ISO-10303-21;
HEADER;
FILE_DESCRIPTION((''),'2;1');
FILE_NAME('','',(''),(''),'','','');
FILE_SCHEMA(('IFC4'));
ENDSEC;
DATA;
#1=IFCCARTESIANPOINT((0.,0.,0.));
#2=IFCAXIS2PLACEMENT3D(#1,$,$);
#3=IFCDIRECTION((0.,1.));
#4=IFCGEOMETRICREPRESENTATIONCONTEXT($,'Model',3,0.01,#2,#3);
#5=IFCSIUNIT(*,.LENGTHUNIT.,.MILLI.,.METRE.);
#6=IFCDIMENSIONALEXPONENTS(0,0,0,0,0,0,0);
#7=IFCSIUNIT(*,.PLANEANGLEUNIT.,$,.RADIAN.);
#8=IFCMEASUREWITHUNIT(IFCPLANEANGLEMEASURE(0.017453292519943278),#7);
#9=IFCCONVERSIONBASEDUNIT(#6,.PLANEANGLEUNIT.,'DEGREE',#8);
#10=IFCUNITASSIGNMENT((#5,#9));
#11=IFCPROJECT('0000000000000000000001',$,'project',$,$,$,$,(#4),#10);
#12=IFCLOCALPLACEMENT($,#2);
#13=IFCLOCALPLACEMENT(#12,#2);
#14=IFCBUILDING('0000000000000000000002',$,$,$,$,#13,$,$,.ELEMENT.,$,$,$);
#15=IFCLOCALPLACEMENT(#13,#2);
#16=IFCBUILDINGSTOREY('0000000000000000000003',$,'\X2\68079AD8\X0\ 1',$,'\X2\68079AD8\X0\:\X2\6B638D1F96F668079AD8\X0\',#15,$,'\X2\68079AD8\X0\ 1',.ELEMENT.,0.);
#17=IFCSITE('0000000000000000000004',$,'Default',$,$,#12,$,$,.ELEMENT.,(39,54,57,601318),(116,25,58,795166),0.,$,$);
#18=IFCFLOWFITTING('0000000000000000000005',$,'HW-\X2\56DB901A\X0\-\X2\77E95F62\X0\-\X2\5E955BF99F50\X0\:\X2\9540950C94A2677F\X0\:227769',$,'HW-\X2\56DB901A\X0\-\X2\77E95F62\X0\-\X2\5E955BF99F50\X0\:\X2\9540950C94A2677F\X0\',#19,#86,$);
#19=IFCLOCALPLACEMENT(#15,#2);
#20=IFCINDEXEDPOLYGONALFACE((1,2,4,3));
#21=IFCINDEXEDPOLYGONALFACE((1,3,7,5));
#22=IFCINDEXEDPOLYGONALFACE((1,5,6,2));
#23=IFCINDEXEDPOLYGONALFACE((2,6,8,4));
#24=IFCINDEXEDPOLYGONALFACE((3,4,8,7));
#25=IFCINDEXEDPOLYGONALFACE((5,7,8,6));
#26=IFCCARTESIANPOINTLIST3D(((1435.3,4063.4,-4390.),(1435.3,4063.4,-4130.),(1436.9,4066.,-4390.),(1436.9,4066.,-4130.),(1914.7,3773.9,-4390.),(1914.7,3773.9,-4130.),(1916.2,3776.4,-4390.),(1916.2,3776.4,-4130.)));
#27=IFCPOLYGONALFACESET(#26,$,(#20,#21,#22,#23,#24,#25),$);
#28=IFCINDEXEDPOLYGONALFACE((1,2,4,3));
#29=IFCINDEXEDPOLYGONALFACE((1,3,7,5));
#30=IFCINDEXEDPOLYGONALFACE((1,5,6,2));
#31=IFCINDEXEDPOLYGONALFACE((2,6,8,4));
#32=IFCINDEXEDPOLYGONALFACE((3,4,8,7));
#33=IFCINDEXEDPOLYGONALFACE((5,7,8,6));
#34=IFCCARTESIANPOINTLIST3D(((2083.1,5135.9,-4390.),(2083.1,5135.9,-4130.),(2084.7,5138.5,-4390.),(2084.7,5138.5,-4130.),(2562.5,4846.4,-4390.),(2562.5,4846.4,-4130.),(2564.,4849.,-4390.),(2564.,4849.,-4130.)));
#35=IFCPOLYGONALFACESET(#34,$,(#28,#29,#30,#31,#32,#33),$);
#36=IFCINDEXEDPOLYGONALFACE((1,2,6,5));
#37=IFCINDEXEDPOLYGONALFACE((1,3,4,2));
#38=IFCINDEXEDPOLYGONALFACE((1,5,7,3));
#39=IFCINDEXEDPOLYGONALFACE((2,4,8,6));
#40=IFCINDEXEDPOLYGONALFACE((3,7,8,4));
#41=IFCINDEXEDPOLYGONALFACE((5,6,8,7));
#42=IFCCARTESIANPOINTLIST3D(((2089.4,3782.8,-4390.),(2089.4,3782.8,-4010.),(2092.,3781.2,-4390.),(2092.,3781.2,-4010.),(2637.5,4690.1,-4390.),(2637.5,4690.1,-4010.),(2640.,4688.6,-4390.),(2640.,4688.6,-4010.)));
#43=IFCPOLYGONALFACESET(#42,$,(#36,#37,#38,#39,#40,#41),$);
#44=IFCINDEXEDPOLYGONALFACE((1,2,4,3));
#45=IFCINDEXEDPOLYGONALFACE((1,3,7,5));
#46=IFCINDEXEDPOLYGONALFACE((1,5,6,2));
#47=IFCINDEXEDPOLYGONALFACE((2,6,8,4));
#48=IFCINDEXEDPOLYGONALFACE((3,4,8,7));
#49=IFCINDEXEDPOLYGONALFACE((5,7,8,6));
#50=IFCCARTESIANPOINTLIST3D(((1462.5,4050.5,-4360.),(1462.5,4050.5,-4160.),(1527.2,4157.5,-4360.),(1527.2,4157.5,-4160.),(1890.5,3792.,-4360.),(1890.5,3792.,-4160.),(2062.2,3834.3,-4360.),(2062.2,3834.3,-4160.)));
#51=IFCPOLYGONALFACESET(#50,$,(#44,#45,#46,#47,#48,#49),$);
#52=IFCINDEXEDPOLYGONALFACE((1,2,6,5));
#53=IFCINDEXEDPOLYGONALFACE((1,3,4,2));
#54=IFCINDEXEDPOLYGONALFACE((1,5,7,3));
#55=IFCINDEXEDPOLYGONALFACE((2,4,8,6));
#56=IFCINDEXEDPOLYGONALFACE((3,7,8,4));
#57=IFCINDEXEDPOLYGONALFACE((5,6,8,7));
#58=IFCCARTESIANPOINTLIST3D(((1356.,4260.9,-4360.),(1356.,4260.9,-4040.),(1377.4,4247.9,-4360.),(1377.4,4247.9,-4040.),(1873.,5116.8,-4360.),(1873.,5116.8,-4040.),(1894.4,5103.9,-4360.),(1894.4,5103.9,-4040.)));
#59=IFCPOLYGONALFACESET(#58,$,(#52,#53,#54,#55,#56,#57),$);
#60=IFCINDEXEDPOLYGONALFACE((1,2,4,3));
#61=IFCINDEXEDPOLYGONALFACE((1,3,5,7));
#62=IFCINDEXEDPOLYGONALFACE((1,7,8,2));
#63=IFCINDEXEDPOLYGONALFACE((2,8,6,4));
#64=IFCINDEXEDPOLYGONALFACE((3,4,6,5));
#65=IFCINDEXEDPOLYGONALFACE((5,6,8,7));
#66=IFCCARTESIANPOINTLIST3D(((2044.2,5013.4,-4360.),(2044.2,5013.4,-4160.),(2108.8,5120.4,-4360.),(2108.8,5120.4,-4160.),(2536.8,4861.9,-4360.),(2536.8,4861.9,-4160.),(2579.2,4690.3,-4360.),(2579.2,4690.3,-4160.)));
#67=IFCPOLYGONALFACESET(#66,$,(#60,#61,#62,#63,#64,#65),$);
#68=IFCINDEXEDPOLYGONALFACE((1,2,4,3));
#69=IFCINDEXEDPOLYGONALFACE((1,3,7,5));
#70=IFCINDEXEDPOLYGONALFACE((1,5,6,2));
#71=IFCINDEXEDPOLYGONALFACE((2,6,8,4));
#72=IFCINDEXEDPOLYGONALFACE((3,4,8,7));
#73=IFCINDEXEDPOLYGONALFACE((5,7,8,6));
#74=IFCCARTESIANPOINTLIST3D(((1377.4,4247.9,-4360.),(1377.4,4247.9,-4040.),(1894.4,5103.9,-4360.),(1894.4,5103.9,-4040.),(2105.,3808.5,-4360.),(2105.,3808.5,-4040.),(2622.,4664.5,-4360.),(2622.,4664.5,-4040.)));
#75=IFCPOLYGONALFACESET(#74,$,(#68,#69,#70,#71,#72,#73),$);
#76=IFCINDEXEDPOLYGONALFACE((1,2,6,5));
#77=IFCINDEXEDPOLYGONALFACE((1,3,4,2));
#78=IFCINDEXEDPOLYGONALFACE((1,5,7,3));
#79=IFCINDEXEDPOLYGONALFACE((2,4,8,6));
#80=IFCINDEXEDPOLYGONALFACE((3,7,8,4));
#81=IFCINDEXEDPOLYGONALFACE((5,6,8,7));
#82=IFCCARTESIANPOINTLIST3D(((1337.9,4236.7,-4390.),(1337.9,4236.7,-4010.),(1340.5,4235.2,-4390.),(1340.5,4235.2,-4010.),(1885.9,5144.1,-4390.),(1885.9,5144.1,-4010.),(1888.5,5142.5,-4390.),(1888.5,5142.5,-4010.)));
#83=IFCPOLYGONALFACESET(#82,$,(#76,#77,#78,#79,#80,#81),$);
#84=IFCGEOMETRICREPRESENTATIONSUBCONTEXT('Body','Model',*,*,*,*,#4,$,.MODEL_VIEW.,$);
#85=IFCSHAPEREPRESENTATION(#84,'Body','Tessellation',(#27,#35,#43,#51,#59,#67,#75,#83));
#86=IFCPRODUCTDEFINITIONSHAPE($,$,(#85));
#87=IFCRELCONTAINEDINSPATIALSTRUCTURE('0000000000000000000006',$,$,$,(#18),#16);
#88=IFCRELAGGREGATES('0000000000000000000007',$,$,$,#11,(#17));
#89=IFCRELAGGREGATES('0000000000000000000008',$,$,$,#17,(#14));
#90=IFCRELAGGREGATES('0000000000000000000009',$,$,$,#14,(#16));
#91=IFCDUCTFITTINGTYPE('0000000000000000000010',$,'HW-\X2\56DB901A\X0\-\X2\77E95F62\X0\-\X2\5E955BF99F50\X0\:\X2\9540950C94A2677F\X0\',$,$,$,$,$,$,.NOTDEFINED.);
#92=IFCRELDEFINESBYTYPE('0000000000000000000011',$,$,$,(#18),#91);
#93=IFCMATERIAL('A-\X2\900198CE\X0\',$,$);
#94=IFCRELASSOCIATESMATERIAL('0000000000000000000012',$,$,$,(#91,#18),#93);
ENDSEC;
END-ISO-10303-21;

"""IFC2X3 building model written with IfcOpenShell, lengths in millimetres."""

from ifc_helpers import new_model, entity, si_unit, converted_unit, direction, frame, frame_2d, origin, origin_2d_with_axis, place, context, subcontext, project, spatial, polyline, rectangle, outline, extrude, source, transform, mapped, material, type_object, type_shapes, element, save


model = new_model("IFC2X3")

# Units and contexts
model_context = context("Model", 3, precision=0.01, world=origin(), true_north=direction((0.0, 1.0)))
body_context = subcontext(model_context, "Body", "Model", "MODEL_VIEW")
ifc_project = project(units=[si_unit("LENGTHUNIT", "METRE", prefix="MILLI"), converted_unit("PLANEANGLEUNIT", "DEGREE", entity("IfcPlaneAngleMeasure", 0.017453292519943278), si_unit("PLANEANGLEUNIT", "RADIAN"), dimensions=[0, 0, 0, 0, 0, 0, 0])], contexts=[model_context])

# Site, building, storey
site_placement = place(None, origin())
site = spatial("IfcSite", under=ifc_project, at=site_placement, Name="Default", CompositionType="ELEMENT", RefLatitude=(39, 54, 57, 601318), RefLongitude=(116, 25, 58, 795166), RefElevation=0.0)
building_placement = place(site_placement, origin())
building = spatial("IfcBuilding", under=site, at=building_placement, CompositionType="ELEMENT")
storey_placement = place(building_placement, origin())
storey = spatial("IfcBuildingStorey", under=building, at=storey_placement, Name="标高 1", ObjectType="标高:正负零标高", LongName="标高 1", CompositionType="ELEMENT", Elevation=0.0)

# Shared definitions
ifc_material = material(Name="A-送风")

# Flow fitting
duct_fitting_type_1 = type_object("IfcDuctFittingType", Name="HW-四通-矩形-底对齐:镀锌钢板", PredefinedType="NOTDEFINED", material=ifc_material)
shared_shape_1 = source(origin(), body_context, "Body", "SweptSolid", [
    extrude(rectangle(XDim=560.0, YDim=3.0, at=origin_2d_with_axis()), frame((0.0, 626.5, -190.0), z_axis=(0.0, 0.0, 1.0), x_axis=(-1.0, 0.0, 0.0)), (0.0, 0.0, 1.0), 260.0),
    extrude(rectangle(XDim=560.0, YDim=3.0, at=frame_2d((0.0, 0.0), x_axis=(1.0, 0.0))), frame((0.0, -626.5, -190.0), z_axis=(0.0, 0.0, 1.0), x_axis=(-1.0, 0.0, 0.0)), (0.0, 0.0, 1.0), 260.0),
    extrude(rectangle(XDim=1060.0, YDim=3.0, at=frame_2d((0.0, 0.0), x_axis=(1.0, 0.0))), frame((-426.5, 0.0, -190.0), z_axis=(0.0, 0.0, 1.0), x_axis=(0.0, 1.0, 0.0)), (0.0, 0.0, 1.0), 380.0),
    extrude(outline(polyline([(110.5, -198.9), (287.3, -198.9), (-154.7, 243.1), (-243.1, 154.7), (110.5, -198.9)])), frame((-31.2, 562.5, -160.0), z_axis=(0.0, 0.0, 1.0), x_axis=(-0.707107, -0.707107, 0.0)), (0.0, 0.0, 1.0), 200.0),
    extrude(rectangle(XDim=25.0, YDim=1000.0, at=frame_2d((0.0, 0.0), x_axis=(1.0, 0.0))), frame((437.5, 0.0, -160.0), z_axis=(0.0, 0.0, 1.0), x_axis=(-1.0, 0.0, 0.0)), (0.0, 0.0, 1.0), 320.0),
    extrude(outline(polyline([(-62.5, -281.2), (62.5, -281.2), (62.5, 343.8), (-62.5, 218.7), (-62.5, -281.2)])), frame((-31.3, -562.5, -160.0), z_axis=(0.0, 0.0, 1.0), x_axis=(0.0, 1.0, 0.0)), (0.0, 0.0, 1.0), 200.0),
    extrude(rectangle(XDim=850.0, YDim=1000.0, at=origin_2d_with_axis()), frame((0.0, 0.0, -160.0), z_axis=(0.0, 0.0, 1.0), x_axis=(-1.0, 0.0, 0.0)), (0.0, 0.0, 1.0), 320.0),
    extrude(rectangle(XDim=1060.0, YDim=3.0, at=frame_2d((0.0, 0.0), x_axis=(1.0, 0.0))), frame((451.5, 0.0, -190.0), z_axis=(0.0, 0.0, 1.0), x_axis=(0.0, 1.0, 0.0)), (0.0, 0.0, 1.0), 380.0),
])
type_shapes(duct_fitting_type_1, [shared_shape_1])
flow_fitting_1_placement = place(storey_placement, frame((1999.7, 4456.2, -4200.0), z_axis=(0.0, 0.0, 1.0), x_axis=(-0.855987, 0.516998, 0.0)))
element("IfcFlowFitting", 1, at=flow_fitting_1_placement, inside=storey, type_object=duct_fitting_type_1, material=ifc_material, Name="HW-四通-矩形-底对齐:镀锌钢板:227769", ObjectType="HW-四通-矩形-底对齐:镀锌钢板", context=body_context, shape_type="MappedRepresentation", body=[
    mapped(shared_shape_1, transform((0.0, 0.0, 0.0), scale=1.0)),
])

save(model, "model.ifc")
